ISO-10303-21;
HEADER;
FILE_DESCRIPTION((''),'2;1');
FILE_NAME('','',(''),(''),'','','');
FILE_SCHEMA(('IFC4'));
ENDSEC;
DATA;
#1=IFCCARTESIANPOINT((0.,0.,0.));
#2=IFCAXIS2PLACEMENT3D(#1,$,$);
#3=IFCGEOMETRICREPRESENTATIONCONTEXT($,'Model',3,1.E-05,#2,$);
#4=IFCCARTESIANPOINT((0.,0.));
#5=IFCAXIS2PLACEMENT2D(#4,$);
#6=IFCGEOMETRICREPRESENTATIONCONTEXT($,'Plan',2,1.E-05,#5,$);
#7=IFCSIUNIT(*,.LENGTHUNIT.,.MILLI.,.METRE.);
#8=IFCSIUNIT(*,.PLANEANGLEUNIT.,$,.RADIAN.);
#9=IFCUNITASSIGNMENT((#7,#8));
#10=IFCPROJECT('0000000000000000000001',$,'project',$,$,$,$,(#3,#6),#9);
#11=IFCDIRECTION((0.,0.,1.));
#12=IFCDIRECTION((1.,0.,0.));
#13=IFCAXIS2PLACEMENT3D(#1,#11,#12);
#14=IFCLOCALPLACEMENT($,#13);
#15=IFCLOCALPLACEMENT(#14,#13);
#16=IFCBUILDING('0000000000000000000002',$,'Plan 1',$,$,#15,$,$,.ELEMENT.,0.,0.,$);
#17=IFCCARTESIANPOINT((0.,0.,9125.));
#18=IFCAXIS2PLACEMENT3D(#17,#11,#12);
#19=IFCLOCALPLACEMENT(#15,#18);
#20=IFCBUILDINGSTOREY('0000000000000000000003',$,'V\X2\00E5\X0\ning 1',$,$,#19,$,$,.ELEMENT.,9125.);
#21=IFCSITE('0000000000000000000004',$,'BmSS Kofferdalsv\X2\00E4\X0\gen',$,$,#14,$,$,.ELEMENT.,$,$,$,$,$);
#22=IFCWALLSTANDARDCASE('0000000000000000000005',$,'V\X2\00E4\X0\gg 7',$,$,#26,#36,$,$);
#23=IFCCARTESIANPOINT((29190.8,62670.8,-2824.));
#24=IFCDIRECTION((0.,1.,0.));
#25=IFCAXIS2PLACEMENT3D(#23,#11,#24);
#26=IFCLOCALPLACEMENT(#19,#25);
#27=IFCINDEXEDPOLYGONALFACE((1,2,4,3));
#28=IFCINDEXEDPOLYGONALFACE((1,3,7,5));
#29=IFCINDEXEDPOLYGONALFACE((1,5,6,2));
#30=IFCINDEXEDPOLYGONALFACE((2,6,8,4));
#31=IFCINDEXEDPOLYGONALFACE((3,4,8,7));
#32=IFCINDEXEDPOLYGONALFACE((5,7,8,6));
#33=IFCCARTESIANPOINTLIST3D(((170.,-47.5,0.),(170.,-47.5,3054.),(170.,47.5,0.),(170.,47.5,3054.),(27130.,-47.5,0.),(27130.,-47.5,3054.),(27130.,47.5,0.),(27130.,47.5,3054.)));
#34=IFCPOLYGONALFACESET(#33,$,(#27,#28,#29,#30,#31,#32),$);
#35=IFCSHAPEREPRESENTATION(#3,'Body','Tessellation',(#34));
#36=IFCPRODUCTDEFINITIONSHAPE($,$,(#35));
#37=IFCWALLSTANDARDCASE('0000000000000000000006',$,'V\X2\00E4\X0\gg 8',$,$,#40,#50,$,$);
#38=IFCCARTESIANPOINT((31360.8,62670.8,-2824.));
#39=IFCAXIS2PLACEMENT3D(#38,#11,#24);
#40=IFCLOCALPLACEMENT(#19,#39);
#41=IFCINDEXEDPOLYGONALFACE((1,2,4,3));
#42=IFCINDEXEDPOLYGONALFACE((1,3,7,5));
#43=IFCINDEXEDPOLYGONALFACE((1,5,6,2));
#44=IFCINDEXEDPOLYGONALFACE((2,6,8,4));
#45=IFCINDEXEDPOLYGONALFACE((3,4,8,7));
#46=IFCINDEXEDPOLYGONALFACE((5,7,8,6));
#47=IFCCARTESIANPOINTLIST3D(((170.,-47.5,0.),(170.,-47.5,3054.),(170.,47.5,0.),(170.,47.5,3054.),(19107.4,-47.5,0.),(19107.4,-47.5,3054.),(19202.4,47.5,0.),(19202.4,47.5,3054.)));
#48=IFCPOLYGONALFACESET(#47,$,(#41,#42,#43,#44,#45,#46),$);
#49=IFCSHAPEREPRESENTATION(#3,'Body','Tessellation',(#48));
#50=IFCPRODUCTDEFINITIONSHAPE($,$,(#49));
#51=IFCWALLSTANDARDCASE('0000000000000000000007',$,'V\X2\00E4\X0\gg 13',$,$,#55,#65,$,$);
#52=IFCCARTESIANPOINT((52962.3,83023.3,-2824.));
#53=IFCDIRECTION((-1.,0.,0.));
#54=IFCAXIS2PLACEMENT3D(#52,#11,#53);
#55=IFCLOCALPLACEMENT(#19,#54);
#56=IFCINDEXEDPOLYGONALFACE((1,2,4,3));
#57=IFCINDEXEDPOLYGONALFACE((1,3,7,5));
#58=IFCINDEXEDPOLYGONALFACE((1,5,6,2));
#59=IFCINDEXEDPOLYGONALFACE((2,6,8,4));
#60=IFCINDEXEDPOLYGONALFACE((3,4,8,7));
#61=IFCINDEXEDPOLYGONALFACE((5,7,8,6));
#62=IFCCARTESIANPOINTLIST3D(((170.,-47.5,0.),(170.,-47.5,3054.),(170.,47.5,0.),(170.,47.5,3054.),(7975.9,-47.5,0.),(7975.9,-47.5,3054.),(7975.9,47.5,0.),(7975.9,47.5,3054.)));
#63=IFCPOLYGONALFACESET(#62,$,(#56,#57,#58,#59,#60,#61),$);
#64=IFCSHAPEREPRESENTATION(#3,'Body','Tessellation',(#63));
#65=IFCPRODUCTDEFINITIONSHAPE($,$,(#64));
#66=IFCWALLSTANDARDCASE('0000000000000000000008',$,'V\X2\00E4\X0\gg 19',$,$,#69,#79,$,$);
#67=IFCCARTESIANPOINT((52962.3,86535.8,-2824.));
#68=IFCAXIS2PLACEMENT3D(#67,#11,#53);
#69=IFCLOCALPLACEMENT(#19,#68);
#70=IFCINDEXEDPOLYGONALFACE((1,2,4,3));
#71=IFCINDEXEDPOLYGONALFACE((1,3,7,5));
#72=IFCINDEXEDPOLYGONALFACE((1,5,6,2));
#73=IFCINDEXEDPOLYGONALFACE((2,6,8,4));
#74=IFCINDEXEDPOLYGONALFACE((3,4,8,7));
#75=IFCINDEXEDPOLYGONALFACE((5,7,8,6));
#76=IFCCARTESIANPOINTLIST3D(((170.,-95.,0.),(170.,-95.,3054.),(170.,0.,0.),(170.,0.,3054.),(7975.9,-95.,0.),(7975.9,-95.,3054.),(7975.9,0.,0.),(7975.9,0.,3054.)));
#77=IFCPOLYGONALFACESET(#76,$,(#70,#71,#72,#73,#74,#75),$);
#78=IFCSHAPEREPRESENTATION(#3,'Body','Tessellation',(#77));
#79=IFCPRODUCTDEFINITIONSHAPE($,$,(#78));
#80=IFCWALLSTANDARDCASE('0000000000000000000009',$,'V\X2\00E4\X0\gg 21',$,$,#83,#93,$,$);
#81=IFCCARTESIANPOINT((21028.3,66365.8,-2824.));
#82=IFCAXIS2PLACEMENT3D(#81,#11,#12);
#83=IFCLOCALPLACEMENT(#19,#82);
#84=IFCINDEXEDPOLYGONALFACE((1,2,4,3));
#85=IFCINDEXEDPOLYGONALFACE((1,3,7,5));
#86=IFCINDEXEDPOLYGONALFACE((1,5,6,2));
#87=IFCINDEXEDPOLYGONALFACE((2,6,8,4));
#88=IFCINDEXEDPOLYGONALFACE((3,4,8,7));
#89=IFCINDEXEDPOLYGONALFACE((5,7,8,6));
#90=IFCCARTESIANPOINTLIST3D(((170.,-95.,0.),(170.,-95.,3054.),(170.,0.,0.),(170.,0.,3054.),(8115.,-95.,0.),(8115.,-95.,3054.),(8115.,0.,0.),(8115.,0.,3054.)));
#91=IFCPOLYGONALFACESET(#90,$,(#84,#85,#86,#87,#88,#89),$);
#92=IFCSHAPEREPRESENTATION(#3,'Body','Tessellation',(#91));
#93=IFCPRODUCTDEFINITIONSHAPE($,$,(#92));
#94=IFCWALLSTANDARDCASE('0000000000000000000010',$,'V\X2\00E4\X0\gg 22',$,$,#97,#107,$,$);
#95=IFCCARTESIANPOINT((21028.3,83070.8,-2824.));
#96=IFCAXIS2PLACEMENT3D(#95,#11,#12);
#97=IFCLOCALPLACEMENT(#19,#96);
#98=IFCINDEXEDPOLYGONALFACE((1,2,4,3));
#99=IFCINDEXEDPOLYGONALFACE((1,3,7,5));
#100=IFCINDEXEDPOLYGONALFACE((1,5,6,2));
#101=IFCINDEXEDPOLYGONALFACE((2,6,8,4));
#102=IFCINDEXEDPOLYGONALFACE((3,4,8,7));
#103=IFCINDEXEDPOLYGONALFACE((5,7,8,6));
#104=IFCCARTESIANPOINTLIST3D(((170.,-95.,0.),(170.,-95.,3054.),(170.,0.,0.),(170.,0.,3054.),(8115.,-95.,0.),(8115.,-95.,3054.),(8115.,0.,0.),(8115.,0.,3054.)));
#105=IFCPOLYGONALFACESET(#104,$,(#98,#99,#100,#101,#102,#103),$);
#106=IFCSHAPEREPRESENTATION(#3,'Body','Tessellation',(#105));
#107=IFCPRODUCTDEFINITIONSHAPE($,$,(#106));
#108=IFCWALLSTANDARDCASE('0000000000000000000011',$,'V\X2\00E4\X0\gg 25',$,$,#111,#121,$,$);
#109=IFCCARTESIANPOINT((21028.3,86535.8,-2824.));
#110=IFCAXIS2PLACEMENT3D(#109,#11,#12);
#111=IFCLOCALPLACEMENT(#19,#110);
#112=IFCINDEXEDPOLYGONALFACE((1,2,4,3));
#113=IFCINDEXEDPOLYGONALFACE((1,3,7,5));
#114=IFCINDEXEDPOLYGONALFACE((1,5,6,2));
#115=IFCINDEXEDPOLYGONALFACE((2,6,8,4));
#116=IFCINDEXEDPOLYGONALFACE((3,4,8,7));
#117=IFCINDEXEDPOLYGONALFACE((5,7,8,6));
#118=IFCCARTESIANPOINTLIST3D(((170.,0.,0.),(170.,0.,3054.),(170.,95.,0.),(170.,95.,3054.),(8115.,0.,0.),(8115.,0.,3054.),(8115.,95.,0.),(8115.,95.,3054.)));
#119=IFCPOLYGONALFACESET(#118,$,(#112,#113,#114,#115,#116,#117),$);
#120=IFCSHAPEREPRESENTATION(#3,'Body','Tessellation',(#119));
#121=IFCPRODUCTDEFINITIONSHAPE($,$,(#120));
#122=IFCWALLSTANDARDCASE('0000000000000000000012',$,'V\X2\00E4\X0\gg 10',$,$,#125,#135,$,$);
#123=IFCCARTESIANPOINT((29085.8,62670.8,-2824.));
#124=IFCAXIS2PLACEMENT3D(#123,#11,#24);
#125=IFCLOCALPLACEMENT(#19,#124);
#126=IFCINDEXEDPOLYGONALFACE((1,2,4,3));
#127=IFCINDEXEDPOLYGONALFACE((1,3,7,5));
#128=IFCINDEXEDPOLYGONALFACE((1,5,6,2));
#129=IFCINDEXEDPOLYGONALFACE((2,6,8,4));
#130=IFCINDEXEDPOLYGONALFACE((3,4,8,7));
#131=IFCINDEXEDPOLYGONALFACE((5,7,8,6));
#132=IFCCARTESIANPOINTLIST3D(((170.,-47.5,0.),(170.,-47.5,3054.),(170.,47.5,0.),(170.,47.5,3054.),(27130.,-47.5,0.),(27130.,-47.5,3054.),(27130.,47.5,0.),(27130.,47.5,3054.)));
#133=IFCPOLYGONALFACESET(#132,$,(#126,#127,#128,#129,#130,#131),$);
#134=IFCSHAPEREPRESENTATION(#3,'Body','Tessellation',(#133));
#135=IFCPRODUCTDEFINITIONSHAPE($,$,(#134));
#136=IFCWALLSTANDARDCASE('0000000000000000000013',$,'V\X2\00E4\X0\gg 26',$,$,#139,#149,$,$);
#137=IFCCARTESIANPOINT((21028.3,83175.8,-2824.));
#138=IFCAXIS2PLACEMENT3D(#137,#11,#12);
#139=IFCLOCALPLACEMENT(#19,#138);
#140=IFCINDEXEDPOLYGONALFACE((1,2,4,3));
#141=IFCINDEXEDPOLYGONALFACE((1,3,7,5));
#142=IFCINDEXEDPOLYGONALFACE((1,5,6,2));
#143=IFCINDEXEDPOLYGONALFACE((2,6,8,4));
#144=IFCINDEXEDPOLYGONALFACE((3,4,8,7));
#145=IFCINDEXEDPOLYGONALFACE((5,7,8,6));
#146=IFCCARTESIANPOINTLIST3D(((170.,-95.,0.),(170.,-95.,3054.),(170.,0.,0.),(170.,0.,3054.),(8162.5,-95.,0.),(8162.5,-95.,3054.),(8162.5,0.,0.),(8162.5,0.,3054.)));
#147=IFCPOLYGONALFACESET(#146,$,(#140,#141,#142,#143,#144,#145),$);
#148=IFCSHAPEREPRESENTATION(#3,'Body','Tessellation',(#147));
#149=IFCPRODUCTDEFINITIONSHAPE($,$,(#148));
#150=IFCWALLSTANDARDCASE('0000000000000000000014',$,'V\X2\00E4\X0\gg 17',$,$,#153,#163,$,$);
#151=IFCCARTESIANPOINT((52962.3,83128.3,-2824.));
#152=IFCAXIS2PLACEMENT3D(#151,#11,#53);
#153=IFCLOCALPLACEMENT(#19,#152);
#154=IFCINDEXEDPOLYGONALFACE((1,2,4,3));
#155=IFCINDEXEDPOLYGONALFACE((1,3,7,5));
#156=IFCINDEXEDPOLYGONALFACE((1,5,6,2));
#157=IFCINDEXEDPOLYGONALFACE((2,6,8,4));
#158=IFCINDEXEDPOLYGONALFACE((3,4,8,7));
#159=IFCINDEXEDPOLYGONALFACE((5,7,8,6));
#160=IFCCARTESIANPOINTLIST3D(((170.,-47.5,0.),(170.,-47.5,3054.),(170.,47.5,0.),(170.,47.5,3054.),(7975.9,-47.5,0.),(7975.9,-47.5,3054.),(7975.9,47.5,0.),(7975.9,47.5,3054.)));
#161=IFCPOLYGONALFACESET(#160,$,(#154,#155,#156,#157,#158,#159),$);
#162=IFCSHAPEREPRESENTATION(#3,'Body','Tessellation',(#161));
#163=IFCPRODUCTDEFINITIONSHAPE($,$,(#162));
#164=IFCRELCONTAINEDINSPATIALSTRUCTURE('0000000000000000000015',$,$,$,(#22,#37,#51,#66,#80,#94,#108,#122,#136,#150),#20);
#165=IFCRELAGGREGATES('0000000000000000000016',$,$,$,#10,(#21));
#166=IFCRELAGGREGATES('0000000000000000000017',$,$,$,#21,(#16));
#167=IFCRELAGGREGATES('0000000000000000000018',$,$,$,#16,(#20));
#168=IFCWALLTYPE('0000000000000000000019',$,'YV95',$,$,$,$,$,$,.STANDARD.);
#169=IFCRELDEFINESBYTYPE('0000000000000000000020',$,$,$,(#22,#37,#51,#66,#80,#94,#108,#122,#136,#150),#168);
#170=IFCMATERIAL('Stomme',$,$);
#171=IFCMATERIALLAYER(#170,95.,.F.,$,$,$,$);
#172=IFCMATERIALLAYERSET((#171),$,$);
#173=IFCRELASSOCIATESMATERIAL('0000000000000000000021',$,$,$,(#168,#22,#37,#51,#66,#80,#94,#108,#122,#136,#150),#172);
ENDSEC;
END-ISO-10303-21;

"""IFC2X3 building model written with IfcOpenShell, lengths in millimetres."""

from ifc_helpers import new_model, si_unit, frame, origin, origin_with_axes, origin_2d, place, context, project, spatial, polyline, segment, composite_curve, outline, extrude, material, layer, layer_set, layer_usage, type_object, element, save


model = new_model("IFC2X3")

# Units and contexts
model_context = context("Model", 3, precision=1e-05, world=origin())
plan_context = context("Plan", 2, precision=1e-05, world=origin_2d())
ifc_project = project(units=[si_unit("LENGTHUNIT", "METRE", prefix="MILLI"), si_unit("PLANEANGLEUNIT", "RADIAN")], contexts=[model_context, plan_context])

# Site, building, storey
site_placement = place(None, origin_with_axes())
site = spatial("IfcSite", under=ifc_project, at=site_placement, Name="BmSS Kofferdalsvägen", CompositionType="ELEMENT")
building_placement = place(site_placement, origin_with_axes())
building = spatial("IfcBuilding", under=site, at=building_placement, Name="Plan 1", CompositionType="ELEMENT", ElevationOfRefHeight=0.0, ElevationOfTerrain=0.0)
storey_placement = place(building_placement, frame((0.0, 0.0, 9125.0), z_axis=(0.0, 0.0, 1.0), x_axis=(1.0, 0.0, 0.0)))
storey = spatial("IfcBuildingStorey", under=building, at=storey_placement, Name="Våning 1", CompositionType="ELEMENT", Elevation=9125.0)

# Walls
ifc_material = material(Name="Stomme")
ifc_layer_1 = layer(ifc_material, 95.0, ventilated=False)
ifc_layer_set_1 = layer_set([ifc_layer_1])
ifc_layer_usage_1 = layer_usage(ifc_layer_set_1, "AXIS2", "POSITIVE", -47.5)
wall_type_1 = type_object("IfcWallType", Name="YV95", PredefinedType="STANDARD", material=ifc_layer_set_1)
wall_1_placement = place(storey_placement, frame((29190.8, 62670.8, -2824.0), z_axis=(0.0, 0.0, 1.0), x_axis=(0.0, 1.0, 0.0)))
element("IfcWallStandardCase", 1, at=wall_1_placement, inside=storey, type_object=wall_type_1, material=ifc_layer_usage_1, Name="Vägg 7", context=model_context, shape_type="SweptSolid", body=[
    extrude(outline(composite_curve([segment(polyline([(170.0, 47.5), (170.0, -47.5)]), True, "CONTINUOUS"), segment(polyline([(170.0, -47.5), (27130.0, -47.5)]), True, "CONTINUOUS"), segment(polyline([(27130.0, -47.5), (27130.0, 47.5)]), True, "CONTINUOUS"), segment(polyline([(27130.0, 47.5), (170.0, 47.5)]), True, "CONTINUOUS")], self_intersect=False)), origin_with_axes(), (0.0, 0.0, 1.0), 3054.0),
])
ifc_layer_usage_2 = layer_usage(ifc_layer_set_1, "AXIS2", "POSITIVE", -47.5)
wall_2_placement = place(storey_placement, frame((31360.8, 62670.8, -2824.0), z_axis=(0.0, 0.0, 1.0), x_axis=(0.0, 1.0, 0.0)))
element("IfcWallStandardCase", 2, at=wall_2_placement, inside=storey, type_object=wall_type_1, material=ifc_layer_usage_2, Name="Vägg 8", context=model_context, shape_type="SweptSolid", body=[
    extrude(outline(composite_curve([segment(polyline([(170.0, 47.5), (170.0, -47.5)]), True, "CONTINUOUS"), segment(polyline([(170.0, -47.5), (19107.4, -47.5)]), True, "CONTINUOUS"), segment(polyline([(19107.4, -47.5), (19202.4, 47.5)]), True, "CONTINUOUS"), segment(polyline([(19202.4, 47.5), (170.0, 47.5)]), True, "CONTINUOUS")], self_intersect=False)), origin_with_axes(), (0.0, 0.0, 1.0), 3054.0),
])
ifc_layer_usage_3 = layer_usage(ifc_layer_set_1, "AXIS2", "POSITIVE", -47.5)
wall_3_placement = place(storey_placement, frame((52962.3, 83023.3, -2824.0), z_axis=(0.0, 0.0, 1.0), x_axis=(-1.0, 0.0, 0.0)))
element("IfcWallStandardCase", 3, at=wall_3_placement, inside=storey, type_object=wall_type_1, material=ifc_layer_usage_3, Name="Vägg 13", context=model_context, shape_type="SweptSolid", body=[
    extrude(outline(composite_curve([segment(polyline([(170.0, 47.5), (170.0, -47.5)]), True, "CONTINUOUS"), segment(polyline([(170.0, -47.5), (7975.9, -47.5)]), True, "CONTINUOUS"), segment(polyline([(7975.9, -47.5), (7975.9, 47.5)]), True, "CONTINUOUS"), segment(polyline([(7975.9, 47.5), (170.0, 47.5)]), True, "CONTINUOUS")], self_intersect=False)), origin_with_axes(), (0.0, 0.0, 1.0), 3054.0),
])
ifc_layer_usage_4 = layer_usage(ifc_layer_set_1, "AXIS2", "POSITIVE", -95.0)
wall_4_placement = place(storey_placement, frame((52962.3, 86535.8, -2824.0), z_axis=(0.0, 0.0, 1.0), x_axis=(-1.0, 0.0, 0.0)))
element("IfcWallStandardCase", 4, at=wall_4_placement, inside=storey, type_object=wall_type_1, material=ifc_layer_usage_4, Name="Vägg 19", context=model_context, shape_type="SweptSolid", body=[
    extrude(outline(composite_curve([segment(polyline([(170.0, 0.0), (170.0, -95.0)]), True, "CONTINUOUS"), segment(polyline([(170.0, -95.0), (7975.9, -95.0)]), True, "CONTINUOUS"), segment(polyline([(7975.9, -95.0), (7975.9, 0.0)]), True, "CONTINUOUS"), segment(polyline([(7975.9, 0.0), (170.0, 0.0)]), True, "CONTINUOUS")], self_intersect=False)), origin_with_axes(), (0.0, 0.0, 1.0), 3054.0),
])
ifc_layer_usage_5 = layer_usage(ifc_layer_set_1, "AXIS2", "POSITIVE", -95.0)
wall_5_placement = place(storey_placement, frame((21028.3, 66365.8, -2824.0), z_axis=(0.0, 0.0, 1.0), x_axis=(1.0, 0.0, 0.0)))
element("IfcWallStandardCase", 5, at=wall_5_placement, inside=storey, type_object=wall_type_1, material=ifc_layer_usage_5, Name="Vägg 21", context=model_context, shape_type="SweptSolid", body=[
    extrude(outline(composite_curve([segment(polyline([(170.0, 0.0), (170.0, -95.0)]), True, "CONTINUOUS"), segment(polyline([(170.0, -95.0), (8115.0, -95.0)]), True, "CONTINUOUS"), segment(polyline([(8115.0, -95.0), (8115.0, 0.0)]), True, "CONTINUOUS"), segment(polyline([(8115.0, 0.0), (170.0, 0.0)]), True, "CONTINUOUS")], self_intersect=False)), origin_with_axes(), (0.0, 0.0, 1.0), 3054.0),
])
ifc_layer_usage_6 = layer_usage(ifc_layer_set_1, "AXIS2", "POSITIVE", -95.0)
wall_6_placement = place(storey_placement, frame((21028.3, 83070.8, -2824.0), z_axis=(0.0, 0.0, 1.0), x_axis=(1.0, 0.0, 0.0)))
element("IfcWallStandardCase", 6, at=wall_6_placement, inside=storey, type_object=wall_type_1, material=ifc_layer_usage_6, Name="Vägg 22", context=model_context, shape_type="SweptSolid", body=[
    extrude(outline(composite_curve([segment(polyline([(170.0, 0.0), (170.0, -95.0)]), True, "CONTINUOUS"), segment(polyline([(170.0, -95.0), (8115.0, -95.0)]), True, "CONTINUOUS"), segment(polyline([(8115.0, -95.0), (8115.0, 0.0)]), True, "CONTINUOUS"), segment(polyline([(8115.0, 0.0), (170.0, 0.0)]), True, "CONTINUOUS")], self_intersect=False)), origin_with_axes(), (0.0, 0.0, 1.0), 3054.0),
])
ifc_layer_usage_7 = layer_usage(ifc_layer_set_1, "AXIS2", "POSITIVE", 0.0)
wall_7_placement = place(storey_placement, frame((21028.3, 86535.8, -2824.0), z_axis=(0.0, 0.0, 1.0), x_axis=(1.0, 0.0, 0.0)))
element("IfcWallStandardCase", 7, at=wall_7_placement, inside=storey, type_object=wall_type_1, material=ifc_layer_usage_7, Name="Vägg 25", context=model_context, shape_type="SweptSolid", body=[
    extrude(outline(composite_curve([segment(polyline([(170.0, 95.0), (170.0, 0.0)]), True, "CONTINUOUS"), segment(polyline([(170.0, 0.0), (8115.0, 0.0)]), True, "CONTINUOUS"), segment(polyline([(8115.0, 0.0), (8115.0, 95.0)]), True, "CONTINUOUS"), segment(polyline([(8115.0, 95.0), (170.0, 95.0)]), True, "CONTINUOUS")], self_intersect=False)), origin_with_axes(), (0.0, 0.0, 1.0), 3054.0),
])
ifc_layer_usage_8 = layer_usage(ifc_layer_set_1, "AXIS2", "POSITIVE", -47.5)
wall_8_placement = place(storey_placement, frame((29085.8, 62670.8, -2824.0), z_axis=(0.0, 0.0, 1.0), x_axis=(0.0, 1.0, 0.0)))
element("IfcWallStandardCase", 8, at=wall_8_placement, inside=storey, type_object=wall_type_1, material=ifc_layer_usage_8, Name="Vägg 10", context=model_context, shape_type="SweptSolid", body=[
    extrude(outline(composite_curve([segment(polyline([(170.0, 47.5), (170.0, -47.5)]), True, "CONTINUOUS"), segment(polyline([(170.0, -47.5), (27130.0, -47.5)]), True, "CONTINUOUS"), segment(polyline([(27130.0, -47.5), (27130.0, 47.5)]), True, "CONTINUOUS"), segment(polyline([(27130.0, 47.5), (170.0, 47.5)]), True, "CONTINUOUS")], self_intersect=False)), origin_with_axes(), (0.0, 0.0, 1.0), 3054.0),
])
ifc_layer_usage_9 = layer_usage(ifc_layer_set_1, "AXIS2", "POSITIVE", -95.0)
wall_9_placement = place(storey_placement, frame((21028.3, 83175.8, -2824.0), z_axis=(0.0, 0.0, 1.0), x_axis=(1.0, 0.0, 0.0)))
element("IfcWallStandardCase", 9, at=wall_9_placement, inside=storey, type_object=wall_type_1, material=ifc_layer_usage_9, Name="Vägg 26", context=model_context, shape_type="SweptSolid", body=[
    extrude(outline(composite_curve([segment(polyline([(170.0, 0.0), (170.0, -95.0)]), True, "CONTINUOUS"), segment(polyline([(170.0, -95.0), (8162.5, -95.0)]), True, "CONTINUOUS"), segment(polyline([(8162.5, -95.0), (8162.5, 0.0)]), True, "CONTINUOUS"), segment(polyline([(8162.5, 0.0), (170.0, 0.0)]), True, "CONTINUOUS")], self_intersect=False)), origin_with_axes(), (0.0, 0.0, 1.0), 3054.0),
])
ifc_layer_usage_10 = layer_usage(ifc_layer_set_1, "AXIS2", "POSITIVE", -47.5)
wall_10_placement = place(storey_placement, frame((52962.3, 83128.3, -2824.0), z_axis=(0.0, 0.0, 1.0), x_axis=(-1.0, 0.0, 0.0)))
element("IfcWallStandardCase", 10, at=wall_10_placement, inside=storey, type_object=wall_type_1, material=ifc_layer_usage_10, Name="Vägg 17", context=model_context, shape_type="SweptSolid", body=[
    extrude(outline(composite_curve([segment(polyline([(170.0, 47.5), (170.0, -47.5)]), True, "CONTINUOUS"), segment(polyline([(170.0, -47.5), (7975.9, -47.5)]), True, "CONTINUOUS"), segment(polyline([(7975.9, -47.5), (7975.9, 47.5)]), True, "CONTINUOUS"), segment(polyline([(7975.9, 47.5), (170.0, 47.5)]), True, "CONTINUOUS")], self_intersect=False)), origin_with_axes(), (0.0, 0.0, 1.0), 3054.0),
])

save(model, "model.ifc")
